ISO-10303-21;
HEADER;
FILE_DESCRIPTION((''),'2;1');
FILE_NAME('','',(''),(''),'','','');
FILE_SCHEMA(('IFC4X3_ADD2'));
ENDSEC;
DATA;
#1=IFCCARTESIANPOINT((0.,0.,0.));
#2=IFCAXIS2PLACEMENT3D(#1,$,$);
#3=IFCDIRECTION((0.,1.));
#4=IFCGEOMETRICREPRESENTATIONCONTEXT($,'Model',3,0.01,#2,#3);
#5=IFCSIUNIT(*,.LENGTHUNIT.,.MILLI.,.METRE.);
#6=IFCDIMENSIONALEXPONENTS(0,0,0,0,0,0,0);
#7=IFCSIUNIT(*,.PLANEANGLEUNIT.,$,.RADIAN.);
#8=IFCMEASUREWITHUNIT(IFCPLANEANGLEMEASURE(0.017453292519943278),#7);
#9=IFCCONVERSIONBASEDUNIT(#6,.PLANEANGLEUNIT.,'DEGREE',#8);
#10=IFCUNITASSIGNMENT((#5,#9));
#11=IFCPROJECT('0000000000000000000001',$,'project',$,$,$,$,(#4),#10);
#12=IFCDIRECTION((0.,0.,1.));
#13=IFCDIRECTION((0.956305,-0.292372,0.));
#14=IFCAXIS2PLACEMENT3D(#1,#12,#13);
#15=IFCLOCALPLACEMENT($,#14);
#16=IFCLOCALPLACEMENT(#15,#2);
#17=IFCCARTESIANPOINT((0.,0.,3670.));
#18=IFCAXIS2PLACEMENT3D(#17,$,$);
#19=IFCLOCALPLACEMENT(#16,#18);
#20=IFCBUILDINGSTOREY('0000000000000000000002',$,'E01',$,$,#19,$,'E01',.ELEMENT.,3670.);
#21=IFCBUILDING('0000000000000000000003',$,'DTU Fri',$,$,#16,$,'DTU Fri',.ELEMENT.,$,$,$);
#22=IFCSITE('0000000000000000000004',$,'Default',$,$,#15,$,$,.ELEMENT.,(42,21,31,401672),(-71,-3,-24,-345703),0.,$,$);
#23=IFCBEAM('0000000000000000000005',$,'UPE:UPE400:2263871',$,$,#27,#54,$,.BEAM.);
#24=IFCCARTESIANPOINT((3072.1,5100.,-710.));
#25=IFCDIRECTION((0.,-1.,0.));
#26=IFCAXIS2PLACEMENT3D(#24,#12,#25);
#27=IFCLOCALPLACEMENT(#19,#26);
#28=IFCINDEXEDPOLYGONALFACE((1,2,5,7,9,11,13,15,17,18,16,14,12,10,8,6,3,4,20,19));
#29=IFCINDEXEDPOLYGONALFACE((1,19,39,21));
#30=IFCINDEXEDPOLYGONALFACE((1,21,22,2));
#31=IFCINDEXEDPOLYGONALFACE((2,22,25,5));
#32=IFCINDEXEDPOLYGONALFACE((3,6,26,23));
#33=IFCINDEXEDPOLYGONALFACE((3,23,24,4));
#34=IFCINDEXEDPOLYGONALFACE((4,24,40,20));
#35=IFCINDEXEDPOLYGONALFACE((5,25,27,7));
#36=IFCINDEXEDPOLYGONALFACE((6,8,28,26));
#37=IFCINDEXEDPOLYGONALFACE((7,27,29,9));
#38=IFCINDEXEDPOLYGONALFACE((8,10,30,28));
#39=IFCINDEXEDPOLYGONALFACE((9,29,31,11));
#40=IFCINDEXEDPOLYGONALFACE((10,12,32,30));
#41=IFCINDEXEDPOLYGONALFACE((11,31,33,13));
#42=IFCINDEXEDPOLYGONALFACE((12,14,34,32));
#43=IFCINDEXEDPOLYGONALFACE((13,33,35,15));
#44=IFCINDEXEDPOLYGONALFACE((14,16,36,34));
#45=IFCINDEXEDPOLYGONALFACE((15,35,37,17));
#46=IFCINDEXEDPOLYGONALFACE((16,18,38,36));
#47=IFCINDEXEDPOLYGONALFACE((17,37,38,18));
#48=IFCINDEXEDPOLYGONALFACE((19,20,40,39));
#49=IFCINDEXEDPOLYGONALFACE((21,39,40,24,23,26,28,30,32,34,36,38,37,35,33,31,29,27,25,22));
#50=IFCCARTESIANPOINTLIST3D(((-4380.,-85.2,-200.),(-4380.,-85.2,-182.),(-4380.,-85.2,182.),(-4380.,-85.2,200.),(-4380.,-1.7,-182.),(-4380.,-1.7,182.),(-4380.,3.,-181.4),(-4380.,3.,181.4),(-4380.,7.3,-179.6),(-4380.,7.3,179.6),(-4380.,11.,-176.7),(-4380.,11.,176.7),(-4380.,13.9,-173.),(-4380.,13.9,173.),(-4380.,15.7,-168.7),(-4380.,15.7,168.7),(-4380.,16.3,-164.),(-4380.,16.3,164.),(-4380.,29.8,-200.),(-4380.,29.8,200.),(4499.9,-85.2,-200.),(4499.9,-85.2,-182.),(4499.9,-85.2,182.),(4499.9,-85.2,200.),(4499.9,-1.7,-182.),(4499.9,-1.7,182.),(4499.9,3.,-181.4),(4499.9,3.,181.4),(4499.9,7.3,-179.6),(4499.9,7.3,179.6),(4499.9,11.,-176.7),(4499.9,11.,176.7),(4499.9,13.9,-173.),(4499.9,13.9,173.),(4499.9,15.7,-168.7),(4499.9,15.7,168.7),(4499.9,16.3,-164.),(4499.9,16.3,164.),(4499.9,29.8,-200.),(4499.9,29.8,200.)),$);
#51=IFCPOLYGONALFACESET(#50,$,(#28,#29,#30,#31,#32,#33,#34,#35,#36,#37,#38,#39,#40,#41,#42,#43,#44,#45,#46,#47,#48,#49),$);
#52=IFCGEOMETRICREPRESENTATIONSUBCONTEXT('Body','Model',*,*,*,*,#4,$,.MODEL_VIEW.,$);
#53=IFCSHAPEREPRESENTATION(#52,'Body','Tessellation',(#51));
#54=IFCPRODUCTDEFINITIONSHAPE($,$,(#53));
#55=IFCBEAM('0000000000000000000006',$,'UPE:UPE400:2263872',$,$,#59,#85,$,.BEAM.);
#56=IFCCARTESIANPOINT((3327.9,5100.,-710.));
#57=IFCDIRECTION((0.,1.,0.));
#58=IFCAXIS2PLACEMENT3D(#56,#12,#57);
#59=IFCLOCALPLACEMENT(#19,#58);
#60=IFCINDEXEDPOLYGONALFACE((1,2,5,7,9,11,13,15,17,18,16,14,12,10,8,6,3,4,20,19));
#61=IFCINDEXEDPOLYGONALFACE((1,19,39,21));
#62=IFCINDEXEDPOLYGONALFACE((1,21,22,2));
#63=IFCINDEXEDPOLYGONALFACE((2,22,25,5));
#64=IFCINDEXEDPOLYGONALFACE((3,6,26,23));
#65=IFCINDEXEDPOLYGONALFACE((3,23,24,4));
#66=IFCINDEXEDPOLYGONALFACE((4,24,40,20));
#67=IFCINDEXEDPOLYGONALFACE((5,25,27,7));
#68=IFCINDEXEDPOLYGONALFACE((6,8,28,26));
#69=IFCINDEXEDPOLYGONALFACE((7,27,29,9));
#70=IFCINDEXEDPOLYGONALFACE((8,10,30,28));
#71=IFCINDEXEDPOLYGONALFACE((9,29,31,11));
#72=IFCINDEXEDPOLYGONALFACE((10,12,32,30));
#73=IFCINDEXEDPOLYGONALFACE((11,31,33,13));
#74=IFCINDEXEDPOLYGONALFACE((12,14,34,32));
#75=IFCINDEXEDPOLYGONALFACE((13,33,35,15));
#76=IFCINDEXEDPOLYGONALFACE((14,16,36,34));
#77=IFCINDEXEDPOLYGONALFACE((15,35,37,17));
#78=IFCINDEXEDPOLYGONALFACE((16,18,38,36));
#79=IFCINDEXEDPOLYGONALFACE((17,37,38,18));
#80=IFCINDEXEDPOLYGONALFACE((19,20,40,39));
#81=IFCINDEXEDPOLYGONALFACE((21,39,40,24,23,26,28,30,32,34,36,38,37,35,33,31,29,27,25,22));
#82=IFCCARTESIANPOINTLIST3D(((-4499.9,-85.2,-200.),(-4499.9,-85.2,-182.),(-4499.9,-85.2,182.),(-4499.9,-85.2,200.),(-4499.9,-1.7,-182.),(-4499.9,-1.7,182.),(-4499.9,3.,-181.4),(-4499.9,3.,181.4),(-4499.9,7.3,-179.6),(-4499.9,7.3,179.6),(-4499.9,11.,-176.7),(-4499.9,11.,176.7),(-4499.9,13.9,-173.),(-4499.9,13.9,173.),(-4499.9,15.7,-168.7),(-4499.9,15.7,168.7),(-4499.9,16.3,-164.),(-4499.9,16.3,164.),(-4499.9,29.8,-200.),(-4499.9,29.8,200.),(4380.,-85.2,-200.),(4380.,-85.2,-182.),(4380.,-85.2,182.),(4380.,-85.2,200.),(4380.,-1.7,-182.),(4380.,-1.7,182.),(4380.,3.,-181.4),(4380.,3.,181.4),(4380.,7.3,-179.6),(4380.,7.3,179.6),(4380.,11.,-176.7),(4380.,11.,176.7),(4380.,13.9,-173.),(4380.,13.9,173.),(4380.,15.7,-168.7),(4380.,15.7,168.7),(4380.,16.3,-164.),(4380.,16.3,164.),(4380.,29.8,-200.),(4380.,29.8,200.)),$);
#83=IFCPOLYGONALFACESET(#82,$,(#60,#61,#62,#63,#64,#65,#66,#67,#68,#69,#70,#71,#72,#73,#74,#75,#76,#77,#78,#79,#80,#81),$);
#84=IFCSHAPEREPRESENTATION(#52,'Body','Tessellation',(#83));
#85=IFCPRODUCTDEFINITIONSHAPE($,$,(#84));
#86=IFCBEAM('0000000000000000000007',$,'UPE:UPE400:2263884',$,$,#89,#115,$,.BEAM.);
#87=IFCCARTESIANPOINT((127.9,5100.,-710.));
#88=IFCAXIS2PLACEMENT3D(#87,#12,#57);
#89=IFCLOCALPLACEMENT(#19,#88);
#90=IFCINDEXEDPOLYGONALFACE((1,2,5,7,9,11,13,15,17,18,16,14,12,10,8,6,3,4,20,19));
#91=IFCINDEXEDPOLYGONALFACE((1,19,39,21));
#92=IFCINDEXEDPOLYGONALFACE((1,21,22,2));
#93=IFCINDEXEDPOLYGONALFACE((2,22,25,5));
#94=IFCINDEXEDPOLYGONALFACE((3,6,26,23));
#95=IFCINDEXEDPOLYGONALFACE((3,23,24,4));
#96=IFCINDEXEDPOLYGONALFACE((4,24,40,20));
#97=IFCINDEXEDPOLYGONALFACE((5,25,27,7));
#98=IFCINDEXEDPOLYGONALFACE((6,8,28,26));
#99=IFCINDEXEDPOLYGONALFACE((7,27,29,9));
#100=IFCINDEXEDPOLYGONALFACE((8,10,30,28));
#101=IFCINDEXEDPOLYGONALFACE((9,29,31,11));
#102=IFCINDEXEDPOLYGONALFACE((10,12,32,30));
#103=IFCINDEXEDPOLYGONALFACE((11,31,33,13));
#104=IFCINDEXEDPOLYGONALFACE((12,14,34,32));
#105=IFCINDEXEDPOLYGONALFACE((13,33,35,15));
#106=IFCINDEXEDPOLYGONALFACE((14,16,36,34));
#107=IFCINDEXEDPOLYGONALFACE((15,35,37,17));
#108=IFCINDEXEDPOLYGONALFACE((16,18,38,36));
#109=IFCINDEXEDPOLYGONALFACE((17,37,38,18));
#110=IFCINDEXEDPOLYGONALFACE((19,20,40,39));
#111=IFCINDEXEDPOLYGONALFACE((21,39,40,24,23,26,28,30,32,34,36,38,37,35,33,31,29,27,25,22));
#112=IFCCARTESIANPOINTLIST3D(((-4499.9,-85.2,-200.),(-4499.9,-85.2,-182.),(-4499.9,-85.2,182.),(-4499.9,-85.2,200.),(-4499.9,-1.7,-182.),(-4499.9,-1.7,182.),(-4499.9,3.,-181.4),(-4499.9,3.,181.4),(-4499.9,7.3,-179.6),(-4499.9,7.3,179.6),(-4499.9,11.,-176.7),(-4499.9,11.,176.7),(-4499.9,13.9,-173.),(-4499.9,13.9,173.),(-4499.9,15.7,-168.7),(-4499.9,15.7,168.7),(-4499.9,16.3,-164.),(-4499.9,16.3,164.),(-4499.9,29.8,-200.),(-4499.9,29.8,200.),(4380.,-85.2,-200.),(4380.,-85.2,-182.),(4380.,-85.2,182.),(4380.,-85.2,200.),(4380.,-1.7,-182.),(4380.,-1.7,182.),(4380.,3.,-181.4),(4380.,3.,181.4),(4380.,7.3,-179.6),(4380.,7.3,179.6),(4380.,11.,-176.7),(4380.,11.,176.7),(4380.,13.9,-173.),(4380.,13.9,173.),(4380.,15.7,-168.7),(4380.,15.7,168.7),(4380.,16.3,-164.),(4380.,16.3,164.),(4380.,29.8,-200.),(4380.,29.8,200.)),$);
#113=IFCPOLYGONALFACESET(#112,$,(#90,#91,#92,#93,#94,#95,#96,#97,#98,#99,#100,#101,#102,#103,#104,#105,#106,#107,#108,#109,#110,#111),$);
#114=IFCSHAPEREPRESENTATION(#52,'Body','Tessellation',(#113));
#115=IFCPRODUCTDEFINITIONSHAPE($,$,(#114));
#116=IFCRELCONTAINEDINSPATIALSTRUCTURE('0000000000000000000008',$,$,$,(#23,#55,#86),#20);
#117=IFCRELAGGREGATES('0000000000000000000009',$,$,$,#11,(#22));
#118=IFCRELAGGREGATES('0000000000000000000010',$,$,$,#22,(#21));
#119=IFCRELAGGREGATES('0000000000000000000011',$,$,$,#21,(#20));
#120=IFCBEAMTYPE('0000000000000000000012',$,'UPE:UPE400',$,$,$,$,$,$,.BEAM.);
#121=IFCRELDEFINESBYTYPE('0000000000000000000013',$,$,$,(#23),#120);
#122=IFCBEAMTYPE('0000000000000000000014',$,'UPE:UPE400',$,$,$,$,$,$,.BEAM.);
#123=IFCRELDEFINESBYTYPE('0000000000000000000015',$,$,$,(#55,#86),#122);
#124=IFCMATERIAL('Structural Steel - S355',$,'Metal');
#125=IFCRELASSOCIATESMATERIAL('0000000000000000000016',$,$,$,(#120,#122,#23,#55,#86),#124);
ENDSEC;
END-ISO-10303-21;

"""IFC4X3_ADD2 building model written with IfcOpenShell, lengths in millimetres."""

from ifc_helpers import new_model, entity, si_unit, converted_unit, direction, frame, frame_2d, origin, place, context, subcontext, project, spatial, polyline, circle_curve, parameter, trimmed, segment, composite_curve, outline, extrude, source, transform, mapped, material, material_profile, profile_set, profile_usage, type_object, type_shapes, element, save


model = new_model("IFC4X3_ADD2")

# Units and contexts
model_context = context("Model", 3, precision=0.01, world=origin(), true_north=direction((0.0, 1.0)))
body_context = subcontext(model_context, "Body", "Model", "MODEL_VIEW")
ifc_project = project(units=[si_unit("LENGTHUNIT", "METRE", prefix="MILLI"), converted_unit("PLANEANGLEUNIT", "DEGREE", entity("IfcPlaneAngleMeasure", 0.017453292519943278), si_unit("PLANEANGLEUNIT", "RADIAN"), dimensions=[0, 0, 0, 0, 0, 0, 0])], contexts=[model_context])

# Site, building, storey
site_placement = place(None, frame((0.0, 0.0, 0.0), z_axis=(0.0, 0.0, 1.0), x_axis=(0.956305, -0.292372, 0.0)))
site = spatial("IfcSite", under=ifc_project, at=site_placement, Name="Default", CompositionType="ELEMENT", RefLatitude=(42, 21, 31, 401672), RefLongitude=(-71, -3, -24, -345703), RefElevation=0.0)
building_placement = place(site_placement, origin())
building = spatial("IfcBuilding", under=site, at=building_placement, Name="DTU Fri", LongName="DTU Fri", CompositionType="ELEMENT")
storey_placement = place(building_placement, frame((0.0, 0.0, 3670.0)))
storey = spatial("IfcBuildingStorey", under=building, at=storey_placement, Name="E01", LongName="E01", CompositionType="ELEMENT", Elevation=3670.0)

# Beams
ifc_material_1 = material(Name="Structural Steel - S355", Category="Metal")
ifc_material_profile_1 = material_profile(ifc_material_1, outline(composite_curve([segment(polyline([(-200.0, -60.0), (-182.0, -60.0)]), True, "CONTINUOUS"), segment(polyline([(-182.0, -60.0), (-182.0, 23.5)]), True, "CONTINUOUS"), segment(trimmed(circle_curve(frame_2d((-164.0, 23.5), x_axis=(-1.0, 0.0)), 18.0), [parameter(270.0)], [parameter(0.0)], True, "PARAMETER"), False, "CONTINUOUS"), segment(polyline([(-164.0, 41.5), (164.0, 41.5)]), True, "CONTINUOUS"), segment(trimmed(circle_curve(frame_2d((164.0, 23.5), x_axis=(0.0, 1.0)), 18.0), [parameter(270.0)], [parameter(0.0)], True, "PARAMETER"), False, "CONTINUOUS"), segment(polyline([(182.0, 23.5), (182.0, -60.0)]), True, "CONTINUOUS"), segment(polyline([(182.0, -60.0), (200.0, -60.0)]), True, "CONTINUOUS"), segment(polyline([(200.0, -60.0), (200.0, 55.0)]), True, "CONTINUOUS"), segment(polyline([(200.0, 55.0), (-200.0, 55.0)]), True, "CONTINUOUS"), segment(polyline([(-200.0, 55.0), (-200.0, -60.0)]), True, "CONTINUOUS")], self_intersect=False)), Name="UPE400")
ifc_profile_set_1 = profile_set([ifc_material_profile_1], Name="UPE400")
ifc_profile_usage_1 = profile_usage(ifc_profile_set_1, cardinal=8)
beam_type_1 = type_object("IfcBeamType", Name="UPE:UPE400", PredefinedType="BEAM", material=ifc_profile_set_1)
shared_shape_1 = source(origin(), body_context, "Body", "SweptSolid", [
    extrude(outline(composite_curve([segment(polyline([(-200.0, -60.0), (-182.0, -60.0)]), True, "CONTINUOUS"), segment(polyline([(-182.0, -60.0), (-182.0, 23.5)]), True, "CONTINUOUS"), segment(trimmed(circle_curve(frame_2d((-164.0, 23.5), x_axis=(-1.0, 0.0)), 18.0), [parameter(270.0)], [parameter(0.0)], True, "PARAMETER"), False, "CONTINUOUS"), segment(polyline([(-164.0, 41.5), (164.0, 41.5)]), True, "CONTINUOUS"), segment(trimmed(circle_curve(frame_2d((164.0, 23.5), x_axis=(0.0, 1.0)), 18.0), [parameter(270.0)], [parameter(0.0)], True, "PARAMETER"), False, "CONTINUOUS"), segment(polyline([(182.0, 23.5), (182.0, -60.0)]), True, "CONTINUOUS"), segment(polyline([(182.0, -60.0), (200.0, -60.0)]), True, "CONTINUOUS"), segment(polyline([(200.0, -60.0), (200.0, 55.0)]), True, "CONTINUOUS"), segment(polyline([(200.0, 55.0), (-200.0, 55.0)]), True, "CONTINUOUS"), segment(polyline([(-200.0, 55.0), (-200.0, -60.0)]), True, "CONTINUOUS")], self_intersect=False)), frame((-4380.0, -25.2, 0.0), z_axis=(1.0, 0.0, 0.0), x_axis=(0.0, 0.0, -1.0)), (0.0, 0.0, 1.0), 8879.9),
])
type_shapes(beam_type_1, [shared_shape_1])
beam_1_placement = place(storey_placement, frame((3072.1, 5100.0, -710.0), z_axis=(0.0, 0.0, 1.0), x_axis=(0.0, -1.0, 0.0)))
element("IfcBeam", 1, at=beam_1_placement, inside=storey, type_object=beam_type_1, material=ifc_profile_usage_1, Name="UPE:UPE400:2263871", PredefinedType="BEAM", context=body_context, shape_type="MappedRepresentation", body=[
    mapped(shared_shape_1, transform((0.0, 0.0, 0.0), scale=1.0)),
])
beam_type_2 = type_object("IfcBeamType", Name="UPE:UPE400", PredefinedType="BEAM", material=ifc_profile_set_1)
shared_shape_2 = source(origin(), body_context, "Body", "SweptSolid", [
    extrude(outline(composite_curve([segment(polyline([(-200.0, -60.0), (-182.0, -60.0)]), True, "CONTINUOUS"), segment(polyline([(-182.0, -60.0), (-182.0, 23.5)]), True, "CONTINUOUS"), segment(trimmed(circle_curve(frame_2d((-164.0, 23.5), x_axis=(-1.0, 0.0)), 18.0), [parameter(270.0)], [parameter(0.0)], True, "PARAMETER"), False, "CONTINUOUS"), segment(polyline([(-164.0, 41.5), (164.0, 41.5)]), True, "CONTINUOUS"), segment(trimmed(circle_curve(frame_2d((164.0, 23.5), x_axis=(0.0, 1.0)), 18.0), [parameter(270.0)], [parameter(0.0)], True, "PARAMETER"), False, "CONTINUOUS"), segment(polyline([(182.0, 23.5), (182.0, -60.0)]), True, "CONTINUOUS"), segment(polyline([(182.0, -60.0), (200.0, -60.0)]), True, "CONTINUOUS"), segment(polyline([(200.0, -60.0), (200.0, 55.0)]), True, "CONTINUOUS"), segment(polyline([(200.0, 55.0), (-200.0, 55.0)]), True, "CONTINUOUS"), segment(polyline([(-200.0, 55.0), (-200.0, -60.0)]), True, "CONTINUOUS")], self_intersect=False)), frame((-4499.9, -25.2, 0.0), z_axis=(1.0, 0.0, 0.0), x_axis=(0.0, 0.0, -1.0)), (0.0, 0.0, 1.0), 8879.9),
])
type_shapes(beam_type_2, [shared_shape_2])
for number, where, z_axis, x_axis, name in (
    (2, (3327.9, 5100.0, -710.0), (0.0, 0.0, 1.0), (0.0, 1.0, 0.0), "UPE:UPE400:2263872"),
    (3, (127.9, 5100.0, -710.0), (0.0, 0.0, 1.0), (0.0, 1.0, 0.0), "UPE:UPE400:2263884"),
):
    element("IfcBeam", number, at=place(storey_placement, frame(where, z_axis=z_axis, x_axis=x_axis)), inside=storey, type_object=beam_type_2, material=ifc_profile_usage_1, Name=name, PredefinedType="BEAM", context=body_context, shape_type="MappedRepresentation", body=[
        mapped(shared_shape_2, transform((0.0, 0.0, 0.0), scale=1.0)),
    ])

save(model, "model.ifc")
